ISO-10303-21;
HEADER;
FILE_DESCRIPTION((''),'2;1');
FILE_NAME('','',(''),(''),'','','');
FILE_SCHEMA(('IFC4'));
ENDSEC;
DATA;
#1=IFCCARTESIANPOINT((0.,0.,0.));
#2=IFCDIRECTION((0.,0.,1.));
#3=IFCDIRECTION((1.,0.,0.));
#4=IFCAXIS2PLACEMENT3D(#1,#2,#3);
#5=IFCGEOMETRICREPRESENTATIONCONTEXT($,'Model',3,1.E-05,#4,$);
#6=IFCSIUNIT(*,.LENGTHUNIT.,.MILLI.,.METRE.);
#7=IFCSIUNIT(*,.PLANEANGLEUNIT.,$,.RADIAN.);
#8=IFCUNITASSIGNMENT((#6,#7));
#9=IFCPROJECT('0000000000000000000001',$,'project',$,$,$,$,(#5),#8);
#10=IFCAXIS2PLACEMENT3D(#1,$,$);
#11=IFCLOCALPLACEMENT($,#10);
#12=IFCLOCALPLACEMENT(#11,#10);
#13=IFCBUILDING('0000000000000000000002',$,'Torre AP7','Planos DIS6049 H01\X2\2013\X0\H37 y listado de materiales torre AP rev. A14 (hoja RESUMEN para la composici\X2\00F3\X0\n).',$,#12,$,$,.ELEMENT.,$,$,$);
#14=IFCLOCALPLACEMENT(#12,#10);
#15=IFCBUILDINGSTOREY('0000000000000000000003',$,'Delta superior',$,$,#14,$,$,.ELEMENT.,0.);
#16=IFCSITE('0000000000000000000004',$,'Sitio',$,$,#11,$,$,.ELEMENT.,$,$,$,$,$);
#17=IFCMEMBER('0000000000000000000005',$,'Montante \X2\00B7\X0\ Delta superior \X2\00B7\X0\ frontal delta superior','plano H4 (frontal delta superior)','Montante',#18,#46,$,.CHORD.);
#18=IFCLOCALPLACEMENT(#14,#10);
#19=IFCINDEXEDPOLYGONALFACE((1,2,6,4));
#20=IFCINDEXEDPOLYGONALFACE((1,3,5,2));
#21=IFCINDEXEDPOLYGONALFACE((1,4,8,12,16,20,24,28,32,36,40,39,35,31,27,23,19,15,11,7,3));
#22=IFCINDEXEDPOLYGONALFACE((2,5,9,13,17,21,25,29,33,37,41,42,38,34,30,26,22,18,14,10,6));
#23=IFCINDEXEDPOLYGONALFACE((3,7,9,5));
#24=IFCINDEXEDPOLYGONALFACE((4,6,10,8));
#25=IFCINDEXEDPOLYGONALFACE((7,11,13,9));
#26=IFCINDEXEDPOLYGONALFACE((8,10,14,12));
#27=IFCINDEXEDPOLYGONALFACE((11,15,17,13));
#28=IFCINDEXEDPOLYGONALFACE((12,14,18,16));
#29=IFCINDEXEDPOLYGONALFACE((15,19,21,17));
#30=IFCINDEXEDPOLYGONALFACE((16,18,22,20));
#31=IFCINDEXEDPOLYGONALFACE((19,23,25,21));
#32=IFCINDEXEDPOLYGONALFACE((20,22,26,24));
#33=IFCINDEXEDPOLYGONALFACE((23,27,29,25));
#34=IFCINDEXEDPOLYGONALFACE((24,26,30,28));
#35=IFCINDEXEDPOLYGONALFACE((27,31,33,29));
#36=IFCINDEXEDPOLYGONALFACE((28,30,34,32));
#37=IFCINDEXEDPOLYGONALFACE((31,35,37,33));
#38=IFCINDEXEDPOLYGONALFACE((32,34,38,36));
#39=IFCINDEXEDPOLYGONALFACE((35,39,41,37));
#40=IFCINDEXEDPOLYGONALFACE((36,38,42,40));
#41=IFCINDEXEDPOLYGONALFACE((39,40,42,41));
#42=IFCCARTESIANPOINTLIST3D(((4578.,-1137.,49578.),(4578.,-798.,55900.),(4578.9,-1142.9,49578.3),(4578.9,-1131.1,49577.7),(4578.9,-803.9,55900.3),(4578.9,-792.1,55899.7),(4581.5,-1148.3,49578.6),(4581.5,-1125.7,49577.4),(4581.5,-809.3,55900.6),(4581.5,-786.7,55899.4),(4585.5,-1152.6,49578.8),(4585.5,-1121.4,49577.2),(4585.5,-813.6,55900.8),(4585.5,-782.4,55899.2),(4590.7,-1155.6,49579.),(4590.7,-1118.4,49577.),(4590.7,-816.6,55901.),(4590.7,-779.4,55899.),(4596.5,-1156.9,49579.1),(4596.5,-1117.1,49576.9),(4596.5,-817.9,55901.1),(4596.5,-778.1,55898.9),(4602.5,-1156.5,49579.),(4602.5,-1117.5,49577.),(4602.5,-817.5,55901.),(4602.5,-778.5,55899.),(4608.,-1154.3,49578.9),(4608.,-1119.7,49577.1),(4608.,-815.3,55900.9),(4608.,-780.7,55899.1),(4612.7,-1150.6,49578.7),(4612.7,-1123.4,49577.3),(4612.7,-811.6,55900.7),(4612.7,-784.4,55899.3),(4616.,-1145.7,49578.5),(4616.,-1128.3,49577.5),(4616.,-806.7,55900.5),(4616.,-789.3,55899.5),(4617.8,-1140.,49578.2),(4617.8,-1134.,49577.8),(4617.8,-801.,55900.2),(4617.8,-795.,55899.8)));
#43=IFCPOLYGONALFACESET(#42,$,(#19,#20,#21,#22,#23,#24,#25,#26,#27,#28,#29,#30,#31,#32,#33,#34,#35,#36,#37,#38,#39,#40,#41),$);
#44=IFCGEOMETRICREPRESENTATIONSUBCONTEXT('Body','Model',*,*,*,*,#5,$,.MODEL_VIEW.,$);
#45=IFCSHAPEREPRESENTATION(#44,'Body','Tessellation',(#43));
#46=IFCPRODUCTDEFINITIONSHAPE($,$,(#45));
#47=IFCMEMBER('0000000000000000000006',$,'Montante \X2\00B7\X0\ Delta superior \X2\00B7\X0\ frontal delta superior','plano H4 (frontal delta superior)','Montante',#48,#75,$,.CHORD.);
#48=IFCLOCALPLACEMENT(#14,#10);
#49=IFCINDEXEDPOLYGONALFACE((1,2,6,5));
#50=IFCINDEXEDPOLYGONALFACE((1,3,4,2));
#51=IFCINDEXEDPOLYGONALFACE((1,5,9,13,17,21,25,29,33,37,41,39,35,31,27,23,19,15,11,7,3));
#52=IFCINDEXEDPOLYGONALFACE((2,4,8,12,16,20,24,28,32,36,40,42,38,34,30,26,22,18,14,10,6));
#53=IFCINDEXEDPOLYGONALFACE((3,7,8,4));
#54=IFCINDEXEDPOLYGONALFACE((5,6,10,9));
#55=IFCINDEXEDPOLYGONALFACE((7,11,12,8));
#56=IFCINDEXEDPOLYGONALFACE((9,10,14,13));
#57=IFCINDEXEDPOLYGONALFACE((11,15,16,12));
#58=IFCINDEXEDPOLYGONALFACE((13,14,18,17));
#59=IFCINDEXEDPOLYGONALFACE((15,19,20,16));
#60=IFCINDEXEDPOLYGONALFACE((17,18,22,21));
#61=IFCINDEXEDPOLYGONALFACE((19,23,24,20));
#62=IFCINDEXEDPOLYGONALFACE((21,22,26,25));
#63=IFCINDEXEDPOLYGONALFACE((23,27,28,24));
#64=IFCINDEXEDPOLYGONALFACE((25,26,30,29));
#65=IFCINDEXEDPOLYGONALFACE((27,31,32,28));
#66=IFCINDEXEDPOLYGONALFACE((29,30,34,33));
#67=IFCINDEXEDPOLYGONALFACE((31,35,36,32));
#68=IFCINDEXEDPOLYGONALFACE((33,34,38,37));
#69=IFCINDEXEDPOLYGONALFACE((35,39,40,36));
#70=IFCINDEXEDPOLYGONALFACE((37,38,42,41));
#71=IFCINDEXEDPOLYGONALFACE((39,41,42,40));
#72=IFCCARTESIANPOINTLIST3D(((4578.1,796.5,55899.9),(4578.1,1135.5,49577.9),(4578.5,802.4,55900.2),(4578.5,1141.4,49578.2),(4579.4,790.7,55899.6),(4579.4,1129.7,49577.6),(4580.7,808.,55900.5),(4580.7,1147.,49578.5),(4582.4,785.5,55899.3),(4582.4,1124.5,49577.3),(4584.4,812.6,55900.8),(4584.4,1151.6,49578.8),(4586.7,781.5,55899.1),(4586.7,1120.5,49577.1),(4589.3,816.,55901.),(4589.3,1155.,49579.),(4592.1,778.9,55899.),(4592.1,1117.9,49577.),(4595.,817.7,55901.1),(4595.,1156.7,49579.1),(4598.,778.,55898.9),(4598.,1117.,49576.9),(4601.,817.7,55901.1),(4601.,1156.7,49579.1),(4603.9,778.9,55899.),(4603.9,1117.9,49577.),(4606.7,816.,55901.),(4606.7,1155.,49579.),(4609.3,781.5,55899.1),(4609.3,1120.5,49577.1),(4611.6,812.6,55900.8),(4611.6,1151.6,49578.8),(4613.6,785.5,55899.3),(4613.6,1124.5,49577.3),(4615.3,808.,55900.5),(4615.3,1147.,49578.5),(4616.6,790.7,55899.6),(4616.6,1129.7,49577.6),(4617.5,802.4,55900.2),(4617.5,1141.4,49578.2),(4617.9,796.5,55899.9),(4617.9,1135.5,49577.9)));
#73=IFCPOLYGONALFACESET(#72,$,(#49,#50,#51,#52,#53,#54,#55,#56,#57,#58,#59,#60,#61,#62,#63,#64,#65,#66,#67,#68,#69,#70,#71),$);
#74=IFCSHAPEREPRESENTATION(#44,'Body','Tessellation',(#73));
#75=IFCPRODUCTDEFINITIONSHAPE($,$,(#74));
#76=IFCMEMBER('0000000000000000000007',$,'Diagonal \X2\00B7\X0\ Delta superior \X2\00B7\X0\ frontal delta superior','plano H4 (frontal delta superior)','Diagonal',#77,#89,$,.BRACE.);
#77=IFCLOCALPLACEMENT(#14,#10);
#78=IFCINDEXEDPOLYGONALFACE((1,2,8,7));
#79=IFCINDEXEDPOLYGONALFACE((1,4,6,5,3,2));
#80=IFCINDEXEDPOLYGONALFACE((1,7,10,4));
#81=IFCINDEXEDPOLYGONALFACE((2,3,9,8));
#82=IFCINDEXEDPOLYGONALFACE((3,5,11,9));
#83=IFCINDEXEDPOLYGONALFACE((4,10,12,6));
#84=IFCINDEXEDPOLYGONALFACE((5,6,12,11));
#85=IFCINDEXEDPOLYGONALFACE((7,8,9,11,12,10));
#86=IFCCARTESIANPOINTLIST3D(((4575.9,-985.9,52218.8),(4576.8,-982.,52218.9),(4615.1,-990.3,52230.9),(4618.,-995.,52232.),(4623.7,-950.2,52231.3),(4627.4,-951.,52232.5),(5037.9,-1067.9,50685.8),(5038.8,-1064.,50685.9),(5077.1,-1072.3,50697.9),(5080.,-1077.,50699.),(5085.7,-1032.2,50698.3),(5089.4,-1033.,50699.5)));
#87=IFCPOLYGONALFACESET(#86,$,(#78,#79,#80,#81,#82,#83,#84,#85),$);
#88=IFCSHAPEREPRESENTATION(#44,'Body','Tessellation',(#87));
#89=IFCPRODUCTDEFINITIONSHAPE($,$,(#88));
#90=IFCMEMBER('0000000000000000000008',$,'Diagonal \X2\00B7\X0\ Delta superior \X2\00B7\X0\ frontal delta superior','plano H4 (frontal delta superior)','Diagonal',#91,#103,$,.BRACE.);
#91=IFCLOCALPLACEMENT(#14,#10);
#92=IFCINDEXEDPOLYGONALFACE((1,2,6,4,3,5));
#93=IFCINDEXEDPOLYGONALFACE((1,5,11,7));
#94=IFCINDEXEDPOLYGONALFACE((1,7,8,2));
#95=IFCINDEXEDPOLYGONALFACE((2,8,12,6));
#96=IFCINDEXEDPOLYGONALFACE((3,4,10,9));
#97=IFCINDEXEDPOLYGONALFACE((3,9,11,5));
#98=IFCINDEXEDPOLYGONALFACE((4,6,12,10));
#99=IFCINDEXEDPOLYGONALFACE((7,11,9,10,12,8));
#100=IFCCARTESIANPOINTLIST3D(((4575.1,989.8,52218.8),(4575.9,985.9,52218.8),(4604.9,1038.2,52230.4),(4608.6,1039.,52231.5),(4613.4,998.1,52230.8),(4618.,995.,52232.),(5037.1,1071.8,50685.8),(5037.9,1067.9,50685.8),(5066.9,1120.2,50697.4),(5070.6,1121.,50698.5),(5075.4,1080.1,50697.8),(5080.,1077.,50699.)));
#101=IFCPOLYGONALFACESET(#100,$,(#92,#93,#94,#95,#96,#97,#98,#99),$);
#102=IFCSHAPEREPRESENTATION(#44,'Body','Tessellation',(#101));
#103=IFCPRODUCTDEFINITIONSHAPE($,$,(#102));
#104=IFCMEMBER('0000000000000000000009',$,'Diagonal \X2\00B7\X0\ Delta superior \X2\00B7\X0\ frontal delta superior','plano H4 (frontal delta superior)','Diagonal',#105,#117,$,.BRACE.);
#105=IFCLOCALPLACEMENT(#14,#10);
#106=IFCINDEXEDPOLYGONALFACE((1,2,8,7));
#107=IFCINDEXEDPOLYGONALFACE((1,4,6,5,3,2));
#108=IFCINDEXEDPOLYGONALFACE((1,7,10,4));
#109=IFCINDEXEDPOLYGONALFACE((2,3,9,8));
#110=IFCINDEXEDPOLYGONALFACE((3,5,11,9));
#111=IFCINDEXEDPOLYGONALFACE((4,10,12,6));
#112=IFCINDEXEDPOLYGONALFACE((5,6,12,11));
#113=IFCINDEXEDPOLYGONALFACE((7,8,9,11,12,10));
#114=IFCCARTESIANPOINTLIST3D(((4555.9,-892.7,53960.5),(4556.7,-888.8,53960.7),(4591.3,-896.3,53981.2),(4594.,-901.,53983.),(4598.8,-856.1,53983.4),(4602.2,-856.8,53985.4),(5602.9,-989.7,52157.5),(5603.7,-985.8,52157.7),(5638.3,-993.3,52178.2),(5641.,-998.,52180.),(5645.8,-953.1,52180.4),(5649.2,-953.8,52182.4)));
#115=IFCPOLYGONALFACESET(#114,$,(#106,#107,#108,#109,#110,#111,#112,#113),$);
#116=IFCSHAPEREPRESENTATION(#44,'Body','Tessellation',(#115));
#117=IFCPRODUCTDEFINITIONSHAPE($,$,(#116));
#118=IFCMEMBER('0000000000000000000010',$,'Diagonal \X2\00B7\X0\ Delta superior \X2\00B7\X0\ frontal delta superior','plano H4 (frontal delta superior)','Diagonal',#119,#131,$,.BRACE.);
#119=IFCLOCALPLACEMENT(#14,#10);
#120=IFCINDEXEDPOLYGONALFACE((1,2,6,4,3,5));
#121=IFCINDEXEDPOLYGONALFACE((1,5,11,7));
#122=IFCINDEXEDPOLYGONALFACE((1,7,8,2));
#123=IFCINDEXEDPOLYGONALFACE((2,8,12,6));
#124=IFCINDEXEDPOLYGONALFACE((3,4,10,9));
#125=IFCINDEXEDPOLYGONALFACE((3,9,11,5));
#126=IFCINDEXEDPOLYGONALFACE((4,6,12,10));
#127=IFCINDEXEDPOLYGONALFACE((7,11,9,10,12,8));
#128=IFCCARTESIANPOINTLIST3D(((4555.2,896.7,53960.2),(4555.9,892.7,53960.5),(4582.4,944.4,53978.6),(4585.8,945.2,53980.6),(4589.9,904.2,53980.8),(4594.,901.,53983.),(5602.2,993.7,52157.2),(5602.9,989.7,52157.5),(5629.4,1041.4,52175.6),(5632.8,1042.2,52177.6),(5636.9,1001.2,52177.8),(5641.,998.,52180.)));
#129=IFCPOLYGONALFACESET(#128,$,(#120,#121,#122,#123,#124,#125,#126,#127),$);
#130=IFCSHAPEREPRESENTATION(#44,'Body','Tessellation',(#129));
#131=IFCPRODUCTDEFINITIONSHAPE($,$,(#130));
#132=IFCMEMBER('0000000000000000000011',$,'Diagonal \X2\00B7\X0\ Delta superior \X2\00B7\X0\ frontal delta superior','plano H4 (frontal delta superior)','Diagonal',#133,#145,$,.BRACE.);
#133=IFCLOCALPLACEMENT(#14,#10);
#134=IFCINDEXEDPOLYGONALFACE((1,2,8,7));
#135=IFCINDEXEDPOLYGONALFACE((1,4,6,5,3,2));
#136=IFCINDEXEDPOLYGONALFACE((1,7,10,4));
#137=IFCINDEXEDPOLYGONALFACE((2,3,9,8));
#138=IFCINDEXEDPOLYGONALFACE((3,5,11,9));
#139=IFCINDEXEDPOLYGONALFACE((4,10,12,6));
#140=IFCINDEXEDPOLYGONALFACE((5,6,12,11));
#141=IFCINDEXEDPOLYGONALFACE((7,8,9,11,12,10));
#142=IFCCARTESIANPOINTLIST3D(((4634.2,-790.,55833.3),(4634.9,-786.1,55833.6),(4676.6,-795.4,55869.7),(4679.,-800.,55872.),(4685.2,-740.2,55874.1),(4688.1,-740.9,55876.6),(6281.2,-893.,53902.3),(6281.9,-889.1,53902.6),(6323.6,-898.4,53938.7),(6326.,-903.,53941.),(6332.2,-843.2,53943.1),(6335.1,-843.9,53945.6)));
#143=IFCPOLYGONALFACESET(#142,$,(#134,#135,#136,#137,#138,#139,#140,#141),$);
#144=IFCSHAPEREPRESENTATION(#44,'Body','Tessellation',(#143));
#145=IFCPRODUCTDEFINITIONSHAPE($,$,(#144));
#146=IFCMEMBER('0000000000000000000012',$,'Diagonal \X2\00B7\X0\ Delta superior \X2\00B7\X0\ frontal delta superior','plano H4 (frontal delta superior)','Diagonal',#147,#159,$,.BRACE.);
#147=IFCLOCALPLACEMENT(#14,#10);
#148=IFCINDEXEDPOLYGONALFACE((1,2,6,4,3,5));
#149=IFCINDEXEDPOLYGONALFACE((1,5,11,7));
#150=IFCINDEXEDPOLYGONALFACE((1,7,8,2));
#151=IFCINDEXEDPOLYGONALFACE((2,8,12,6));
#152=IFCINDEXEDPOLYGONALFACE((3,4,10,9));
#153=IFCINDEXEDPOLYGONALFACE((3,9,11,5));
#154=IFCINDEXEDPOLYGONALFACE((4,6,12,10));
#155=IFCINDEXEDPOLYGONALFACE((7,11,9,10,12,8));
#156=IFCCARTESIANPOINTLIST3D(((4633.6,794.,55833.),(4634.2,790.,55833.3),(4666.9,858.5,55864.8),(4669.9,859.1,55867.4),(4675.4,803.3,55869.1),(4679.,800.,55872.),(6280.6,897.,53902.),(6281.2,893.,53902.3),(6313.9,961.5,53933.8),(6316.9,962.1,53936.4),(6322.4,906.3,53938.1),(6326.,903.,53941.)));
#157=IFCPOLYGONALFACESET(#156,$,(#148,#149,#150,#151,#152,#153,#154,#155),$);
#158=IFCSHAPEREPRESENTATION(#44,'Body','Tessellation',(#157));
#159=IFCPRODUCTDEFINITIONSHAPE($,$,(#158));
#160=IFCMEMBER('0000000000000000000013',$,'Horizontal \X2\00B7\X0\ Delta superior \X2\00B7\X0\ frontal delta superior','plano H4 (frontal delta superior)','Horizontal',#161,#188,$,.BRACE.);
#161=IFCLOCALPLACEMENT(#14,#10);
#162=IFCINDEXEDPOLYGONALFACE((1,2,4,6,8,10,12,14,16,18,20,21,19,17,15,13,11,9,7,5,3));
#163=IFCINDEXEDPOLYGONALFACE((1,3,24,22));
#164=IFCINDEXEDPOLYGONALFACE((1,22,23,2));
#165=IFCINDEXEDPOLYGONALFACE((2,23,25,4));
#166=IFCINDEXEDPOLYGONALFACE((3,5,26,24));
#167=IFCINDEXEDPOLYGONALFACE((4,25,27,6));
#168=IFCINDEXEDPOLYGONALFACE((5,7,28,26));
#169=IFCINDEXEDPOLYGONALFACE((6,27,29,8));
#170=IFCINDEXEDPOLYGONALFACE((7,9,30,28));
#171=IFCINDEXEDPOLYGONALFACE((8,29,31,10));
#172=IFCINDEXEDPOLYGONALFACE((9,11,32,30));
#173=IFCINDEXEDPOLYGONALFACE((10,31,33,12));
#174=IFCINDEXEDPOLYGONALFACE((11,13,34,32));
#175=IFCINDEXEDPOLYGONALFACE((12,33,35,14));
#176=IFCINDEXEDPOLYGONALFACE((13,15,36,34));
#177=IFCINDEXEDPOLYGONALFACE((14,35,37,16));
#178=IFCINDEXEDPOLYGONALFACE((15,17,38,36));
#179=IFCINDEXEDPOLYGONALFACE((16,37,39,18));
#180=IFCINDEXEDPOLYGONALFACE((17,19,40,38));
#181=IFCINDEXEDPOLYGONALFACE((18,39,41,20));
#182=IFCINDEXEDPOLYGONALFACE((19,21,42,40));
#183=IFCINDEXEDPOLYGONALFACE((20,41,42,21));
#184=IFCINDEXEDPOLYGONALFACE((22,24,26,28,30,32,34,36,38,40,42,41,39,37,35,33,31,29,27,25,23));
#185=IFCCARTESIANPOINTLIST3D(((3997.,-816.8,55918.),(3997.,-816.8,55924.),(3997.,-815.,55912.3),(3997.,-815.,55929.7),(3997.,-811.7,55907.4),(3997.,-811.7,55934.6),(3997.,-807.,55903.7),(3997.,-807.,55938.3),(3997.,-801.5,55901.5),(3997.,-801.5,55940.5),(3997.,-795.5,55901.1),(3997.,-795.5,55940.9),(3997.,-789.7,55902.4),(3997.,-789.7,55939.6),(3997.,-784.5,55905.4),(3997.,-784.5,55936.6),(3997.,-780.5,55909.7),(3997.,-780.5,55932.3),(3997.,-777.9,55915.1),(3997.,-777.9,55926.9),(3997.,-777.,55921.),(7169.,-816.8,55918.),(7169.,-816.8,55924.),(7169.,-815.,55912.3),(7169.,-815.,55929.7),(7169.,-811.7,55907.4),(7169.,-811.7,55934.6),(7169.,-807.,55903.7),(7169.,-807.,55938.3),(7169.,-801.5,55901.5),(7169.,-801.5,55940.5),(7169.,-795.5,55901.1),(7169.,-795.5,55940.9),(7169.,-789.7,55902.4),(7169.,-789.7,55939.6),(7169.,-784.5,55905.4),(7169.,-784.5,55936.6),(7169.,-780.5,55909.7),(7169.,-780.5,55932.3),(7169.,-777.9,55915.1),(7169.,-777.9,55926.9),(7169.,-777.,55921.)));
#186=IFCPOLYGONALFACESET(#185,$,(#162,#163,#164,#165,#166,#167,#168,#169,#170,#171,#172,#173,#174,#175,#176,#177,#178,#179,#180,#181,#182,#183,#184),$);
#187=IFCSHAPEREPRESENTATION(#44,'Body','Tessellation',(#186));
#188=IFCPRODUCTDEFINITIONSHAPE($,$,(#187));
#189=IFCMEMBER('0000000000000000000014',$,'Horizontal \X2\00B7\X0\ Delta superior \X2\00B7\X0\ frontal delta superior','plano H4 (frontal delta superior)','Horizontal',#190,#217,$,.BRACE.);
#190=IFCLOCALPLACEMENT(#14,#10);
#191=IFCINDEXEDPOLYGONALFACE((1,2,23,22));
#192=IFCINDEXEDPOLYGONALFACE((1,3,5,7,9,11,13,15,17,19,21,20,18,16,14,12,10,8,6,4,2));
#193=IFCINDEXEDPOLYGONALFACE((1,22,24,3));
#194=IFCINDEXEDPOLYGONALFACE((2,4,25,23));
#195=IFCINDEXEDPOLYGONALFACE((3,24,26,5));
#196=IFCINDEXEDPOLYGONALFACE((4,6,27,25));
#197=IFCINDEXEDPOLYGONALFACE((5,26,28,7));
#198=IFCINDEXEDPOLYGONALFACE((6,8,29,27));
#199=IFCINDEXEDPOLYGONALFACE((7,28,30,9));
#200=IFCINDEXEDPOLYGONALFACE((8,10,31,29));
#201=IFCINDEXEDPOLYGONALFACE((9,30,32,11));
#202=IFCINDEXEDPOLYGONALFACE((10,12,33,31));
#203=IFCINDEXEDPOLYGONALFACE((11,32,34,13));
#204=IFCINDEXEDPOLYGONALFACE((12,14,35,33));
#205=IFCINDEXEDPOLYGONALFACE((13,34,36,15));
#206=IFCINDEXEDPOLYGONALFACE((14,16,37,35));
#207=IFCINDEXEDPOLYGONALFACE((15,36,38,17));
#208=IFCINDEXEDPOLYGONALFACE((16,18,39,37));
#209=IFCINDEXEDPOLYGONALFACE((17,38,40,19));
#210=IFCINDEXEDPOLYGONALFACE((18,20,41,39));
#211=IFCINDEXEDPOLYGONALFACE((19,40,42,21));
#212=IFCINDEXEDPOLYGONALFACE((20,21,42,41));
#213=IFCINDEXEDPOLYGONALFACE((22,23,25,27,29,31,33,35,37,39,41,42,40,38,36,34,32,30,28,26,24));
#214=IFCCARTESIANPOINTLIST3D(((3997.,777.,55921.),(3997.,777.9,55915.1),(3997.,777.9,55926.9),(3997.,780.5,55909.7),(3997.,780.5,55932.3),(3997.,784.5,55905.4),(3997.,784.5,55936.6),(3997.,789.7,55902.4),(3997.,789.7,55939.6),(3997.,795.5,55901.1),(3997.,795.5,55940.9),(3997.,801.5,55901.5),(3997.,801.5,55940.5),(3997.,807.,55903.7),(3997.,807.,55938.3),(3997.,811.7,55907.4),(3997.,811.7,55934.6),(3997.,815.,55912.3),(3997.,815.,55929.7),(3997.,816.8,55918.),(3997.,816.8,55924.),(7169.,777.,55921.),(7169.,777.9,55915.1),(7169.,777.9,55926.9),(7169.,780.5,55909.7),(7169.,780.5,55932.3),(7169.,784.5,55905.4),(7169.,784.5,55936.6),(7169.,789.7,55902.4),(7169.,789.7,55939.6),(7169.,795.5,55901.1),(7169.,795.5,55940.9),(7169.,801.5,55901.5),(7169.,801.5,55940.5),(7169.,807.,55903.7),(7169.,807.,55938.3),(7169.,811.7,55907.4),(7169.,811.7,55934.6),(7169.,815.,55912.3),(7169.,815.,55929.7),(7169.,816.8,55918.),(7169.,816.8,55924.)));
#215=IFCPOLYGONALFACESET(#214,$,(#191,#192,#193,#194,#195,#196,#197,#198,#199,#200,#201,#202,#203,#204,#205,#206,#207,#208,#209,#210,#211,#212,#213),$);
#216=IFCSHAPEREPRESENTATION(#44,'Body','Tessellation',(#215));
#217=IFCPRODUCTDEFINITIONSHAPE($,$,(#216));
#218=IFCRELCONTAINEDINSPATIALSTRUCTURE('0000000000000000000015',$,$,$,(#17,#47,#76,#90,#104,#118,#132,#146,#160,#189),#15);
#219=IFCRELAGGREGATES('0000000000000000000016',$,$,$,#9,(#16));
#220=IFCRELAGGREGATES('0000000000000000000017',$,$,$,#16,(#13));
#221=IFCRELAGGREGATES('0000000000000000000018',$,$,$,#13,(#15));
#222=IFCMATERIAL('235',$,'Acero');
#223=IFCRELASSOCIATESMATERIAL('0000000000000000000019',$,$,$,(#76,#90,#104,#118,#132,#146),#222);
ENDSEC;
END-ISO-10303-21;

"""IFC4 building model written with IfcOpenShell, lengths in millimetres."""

from ifc_helpers import new_model, si_unit, frame, frame_2d, origin, origin_with_axes, place, context, subcontext, project, spatial, circle, l_section, extrude, material, element, save


model = new_model("IFC4")

# Units and contexts
model_context = context("Model", 3, precision=1e-05, world=origin_with_axes())
body_context = subcontext(model_context, "Body", "Model", "MODEL_VIEW")
ifc_project = project(units=[si_unit("LENGTHUNIT", "METRE", prefix="MILLI"), si_unit("PLANEANGLEUNIT", "RADIAN")], contexts=[model_context])

# Site, building, storey
site_placement = place(None, origin())
site = spatial("IfcSite", under=ifc_project, at=site_placement, Name="Sitio", CompositionType="ELEMENT")
building_placement = place(site_placement, origin())
building = spatial("IfcBuilding", under=site, at=building_placement, Name="Torre AP7", Description="Planos DIS6049 H01–H37 y listado de materiales torre AP rev. A14 (hoja RESUMEN para la composición).", CompositionType="ELEMENT")
storey_placement = place(building_placement, origin())
storey = spatial("IfcBuildingStorey", under=building, at=storey_placement, Name="Delta superior", CompositionType="ELEMENT", Elevation=0.0)

# Members
for number, where, z_axis, x_axis, name in (
    (1, (4598.0, -798.0, 55900.0), (0.0, -0.053545, -0.998565), (-1.0, 0.0, 0.0), "Montante · Delta superior · frontal delta superior"),
    (2, (4598.0, 798.0, 55900.0), (0.0, 0.053545, -0.998565), (0.0, -0.998565, -0.053545), "Montante · Delta superior · frontal delta superior"),
):
    element("IfcMember", number, at=place(storey_placement, frame(where, z_axis=z_axis, x_axis=x_axis)), inside=storey, Name=name, Description="plano H4 (frontal delta superior)", ObjectType="Montante", PredefinedType="CHORD", context=body_context, shape_type="SweptSolid", body=[
        extrude(circle(Radius=20.0), None, (0.0, 0.0, 1.0), 6331.1),
    ])
ifc_material_1 = material(Name="235", Category="Acero")
for number, where, z_axis, x_axis, name in (
    (3, (4618.0, -995.0, 52232.0), (0.288173, -0.051148, -0.956211), (-0.934509, 0.202848, -0.292483), "Diagonal · Delta superior · frontal delta superior"),
    (4, (4618.0, 995.0, 52232.0), (0.288173, 0.051148, -0.956211), (-0.934509, -0.202848, -0.292483), "Diagonal · Delta superior · frontal delta superior"),
):
    element("IfcMember", number, at=place(storey_placement, frame(where, z_axis=z_axis, x_axis=x_axis)), inside=storey, material=ifc_material_1, Name=name, Description="plano H4 (frontal delta superior)", ObjectType="Diagonal", PredefinedType="BRACE", context=body_context, shape_type="SweptSolid", body=[
        extrude(l_section(Depth=45.0, Width=45.0, Thickness=4.0, at=frame_2d((22.5, 22.5))), None, (0.0, 0.0, 1.0), 1603.2),
    ])
for number, where, z_axis, x_axis, name in (
    (5, (4594.0, -901.0, 53983.0), (0.501628, -0.046474, -0.863834), (-0.845685, 0.183933, -0.500984), "Diagonal · Delta superior · frontal delta superior"),
    (6, (4594.0, 901.0, 53983.0), (0.501628, 0.046474, -0.863834), (-0.845685, -0.183933, -0.500984), "Diagonal · Delta superior · frontal delta superior"),
):
    element("IfcMember", number, at=place(storey_placement, frame(where, z_axis=z_axis, x_axis=x_axis)), inside=storey, material=ifc_material_1, Name=name, Description="plano H4 (frontal delta superior)", ObjectType="Diagonal", PredefinedType="BRACE", context=body_context, shape_type="SweptSolid", body=[
        extrude(l_section(Depth=45.0, Width=45.0, Thickness=4.0, at=frame_2d((22.5, 22.5))), None, (0.0, 0.0, 1.0), 2087.2),
    ])
for number, where, z_axis, x_axis, name in (
    (7, (4679.0, -800.0, 55872.0), (0.648406, -0.04055, -0.760214), (-0.745871, 0.166153, -0.645035), "Diagonal · Delta superior · frontal delta superior"),
    (8, (4679.0, 800.0, 55872.0), (0.648406, 0.04055, -0.760214), (-0.745871, -0.166153, -0.645035), "Diagonal · Delta superior · frontal delta superior"),
):
    element("IfcMember", number, at=place(storey_placement, frame(where, z_axis=z_axis, x_axis=x_axis)), inside=storey, material=ifc_material_1, Name=name, Description="plano H4 (frontal delta superior)", ObjectType="Diagonal", PredefinedType="BRACE", context=body_context, shape_type="SweptSolid", body=[
        extrude(l_section(Depth=60.0, Width=60.0, Thickness=4.0, at=frame_2d((30.0, 30.0))), None, (0.0, 0.0, 1.0), 2540.1),
    ])
for number, where, z_axis, x_axis, name in (
    (9, (3997.0, -797.0, 55921.0), (1.0, 0.0, 0.0), (0.0, 1.0, 0.0), "Horizontal · Delta superior · frontal delta superior"),
    (10, (3997.0, 797.0, 55921.0), (1.0, 0.0, 0.0), (0.0, -1.0, 0.0), "Horizontal · Delta superior · frontal delta superior"),
):
    element("IfcMember", number, at=place(storey_placement, frame(where, z_axis=z_axis, x_axis=x_axis)), inside=storey, Name=name, Description="plano H4 (frontal delta superior)", ObjectType="Horizontal", PredefinedType="BRACE", context=body_context, shape_type="SweptSolid", body=[
        extrude(circle(Radius=20.0), None, (0.0, 0.0, 1.0), 3172.0),
    ])

save(model, "model.ifc")
